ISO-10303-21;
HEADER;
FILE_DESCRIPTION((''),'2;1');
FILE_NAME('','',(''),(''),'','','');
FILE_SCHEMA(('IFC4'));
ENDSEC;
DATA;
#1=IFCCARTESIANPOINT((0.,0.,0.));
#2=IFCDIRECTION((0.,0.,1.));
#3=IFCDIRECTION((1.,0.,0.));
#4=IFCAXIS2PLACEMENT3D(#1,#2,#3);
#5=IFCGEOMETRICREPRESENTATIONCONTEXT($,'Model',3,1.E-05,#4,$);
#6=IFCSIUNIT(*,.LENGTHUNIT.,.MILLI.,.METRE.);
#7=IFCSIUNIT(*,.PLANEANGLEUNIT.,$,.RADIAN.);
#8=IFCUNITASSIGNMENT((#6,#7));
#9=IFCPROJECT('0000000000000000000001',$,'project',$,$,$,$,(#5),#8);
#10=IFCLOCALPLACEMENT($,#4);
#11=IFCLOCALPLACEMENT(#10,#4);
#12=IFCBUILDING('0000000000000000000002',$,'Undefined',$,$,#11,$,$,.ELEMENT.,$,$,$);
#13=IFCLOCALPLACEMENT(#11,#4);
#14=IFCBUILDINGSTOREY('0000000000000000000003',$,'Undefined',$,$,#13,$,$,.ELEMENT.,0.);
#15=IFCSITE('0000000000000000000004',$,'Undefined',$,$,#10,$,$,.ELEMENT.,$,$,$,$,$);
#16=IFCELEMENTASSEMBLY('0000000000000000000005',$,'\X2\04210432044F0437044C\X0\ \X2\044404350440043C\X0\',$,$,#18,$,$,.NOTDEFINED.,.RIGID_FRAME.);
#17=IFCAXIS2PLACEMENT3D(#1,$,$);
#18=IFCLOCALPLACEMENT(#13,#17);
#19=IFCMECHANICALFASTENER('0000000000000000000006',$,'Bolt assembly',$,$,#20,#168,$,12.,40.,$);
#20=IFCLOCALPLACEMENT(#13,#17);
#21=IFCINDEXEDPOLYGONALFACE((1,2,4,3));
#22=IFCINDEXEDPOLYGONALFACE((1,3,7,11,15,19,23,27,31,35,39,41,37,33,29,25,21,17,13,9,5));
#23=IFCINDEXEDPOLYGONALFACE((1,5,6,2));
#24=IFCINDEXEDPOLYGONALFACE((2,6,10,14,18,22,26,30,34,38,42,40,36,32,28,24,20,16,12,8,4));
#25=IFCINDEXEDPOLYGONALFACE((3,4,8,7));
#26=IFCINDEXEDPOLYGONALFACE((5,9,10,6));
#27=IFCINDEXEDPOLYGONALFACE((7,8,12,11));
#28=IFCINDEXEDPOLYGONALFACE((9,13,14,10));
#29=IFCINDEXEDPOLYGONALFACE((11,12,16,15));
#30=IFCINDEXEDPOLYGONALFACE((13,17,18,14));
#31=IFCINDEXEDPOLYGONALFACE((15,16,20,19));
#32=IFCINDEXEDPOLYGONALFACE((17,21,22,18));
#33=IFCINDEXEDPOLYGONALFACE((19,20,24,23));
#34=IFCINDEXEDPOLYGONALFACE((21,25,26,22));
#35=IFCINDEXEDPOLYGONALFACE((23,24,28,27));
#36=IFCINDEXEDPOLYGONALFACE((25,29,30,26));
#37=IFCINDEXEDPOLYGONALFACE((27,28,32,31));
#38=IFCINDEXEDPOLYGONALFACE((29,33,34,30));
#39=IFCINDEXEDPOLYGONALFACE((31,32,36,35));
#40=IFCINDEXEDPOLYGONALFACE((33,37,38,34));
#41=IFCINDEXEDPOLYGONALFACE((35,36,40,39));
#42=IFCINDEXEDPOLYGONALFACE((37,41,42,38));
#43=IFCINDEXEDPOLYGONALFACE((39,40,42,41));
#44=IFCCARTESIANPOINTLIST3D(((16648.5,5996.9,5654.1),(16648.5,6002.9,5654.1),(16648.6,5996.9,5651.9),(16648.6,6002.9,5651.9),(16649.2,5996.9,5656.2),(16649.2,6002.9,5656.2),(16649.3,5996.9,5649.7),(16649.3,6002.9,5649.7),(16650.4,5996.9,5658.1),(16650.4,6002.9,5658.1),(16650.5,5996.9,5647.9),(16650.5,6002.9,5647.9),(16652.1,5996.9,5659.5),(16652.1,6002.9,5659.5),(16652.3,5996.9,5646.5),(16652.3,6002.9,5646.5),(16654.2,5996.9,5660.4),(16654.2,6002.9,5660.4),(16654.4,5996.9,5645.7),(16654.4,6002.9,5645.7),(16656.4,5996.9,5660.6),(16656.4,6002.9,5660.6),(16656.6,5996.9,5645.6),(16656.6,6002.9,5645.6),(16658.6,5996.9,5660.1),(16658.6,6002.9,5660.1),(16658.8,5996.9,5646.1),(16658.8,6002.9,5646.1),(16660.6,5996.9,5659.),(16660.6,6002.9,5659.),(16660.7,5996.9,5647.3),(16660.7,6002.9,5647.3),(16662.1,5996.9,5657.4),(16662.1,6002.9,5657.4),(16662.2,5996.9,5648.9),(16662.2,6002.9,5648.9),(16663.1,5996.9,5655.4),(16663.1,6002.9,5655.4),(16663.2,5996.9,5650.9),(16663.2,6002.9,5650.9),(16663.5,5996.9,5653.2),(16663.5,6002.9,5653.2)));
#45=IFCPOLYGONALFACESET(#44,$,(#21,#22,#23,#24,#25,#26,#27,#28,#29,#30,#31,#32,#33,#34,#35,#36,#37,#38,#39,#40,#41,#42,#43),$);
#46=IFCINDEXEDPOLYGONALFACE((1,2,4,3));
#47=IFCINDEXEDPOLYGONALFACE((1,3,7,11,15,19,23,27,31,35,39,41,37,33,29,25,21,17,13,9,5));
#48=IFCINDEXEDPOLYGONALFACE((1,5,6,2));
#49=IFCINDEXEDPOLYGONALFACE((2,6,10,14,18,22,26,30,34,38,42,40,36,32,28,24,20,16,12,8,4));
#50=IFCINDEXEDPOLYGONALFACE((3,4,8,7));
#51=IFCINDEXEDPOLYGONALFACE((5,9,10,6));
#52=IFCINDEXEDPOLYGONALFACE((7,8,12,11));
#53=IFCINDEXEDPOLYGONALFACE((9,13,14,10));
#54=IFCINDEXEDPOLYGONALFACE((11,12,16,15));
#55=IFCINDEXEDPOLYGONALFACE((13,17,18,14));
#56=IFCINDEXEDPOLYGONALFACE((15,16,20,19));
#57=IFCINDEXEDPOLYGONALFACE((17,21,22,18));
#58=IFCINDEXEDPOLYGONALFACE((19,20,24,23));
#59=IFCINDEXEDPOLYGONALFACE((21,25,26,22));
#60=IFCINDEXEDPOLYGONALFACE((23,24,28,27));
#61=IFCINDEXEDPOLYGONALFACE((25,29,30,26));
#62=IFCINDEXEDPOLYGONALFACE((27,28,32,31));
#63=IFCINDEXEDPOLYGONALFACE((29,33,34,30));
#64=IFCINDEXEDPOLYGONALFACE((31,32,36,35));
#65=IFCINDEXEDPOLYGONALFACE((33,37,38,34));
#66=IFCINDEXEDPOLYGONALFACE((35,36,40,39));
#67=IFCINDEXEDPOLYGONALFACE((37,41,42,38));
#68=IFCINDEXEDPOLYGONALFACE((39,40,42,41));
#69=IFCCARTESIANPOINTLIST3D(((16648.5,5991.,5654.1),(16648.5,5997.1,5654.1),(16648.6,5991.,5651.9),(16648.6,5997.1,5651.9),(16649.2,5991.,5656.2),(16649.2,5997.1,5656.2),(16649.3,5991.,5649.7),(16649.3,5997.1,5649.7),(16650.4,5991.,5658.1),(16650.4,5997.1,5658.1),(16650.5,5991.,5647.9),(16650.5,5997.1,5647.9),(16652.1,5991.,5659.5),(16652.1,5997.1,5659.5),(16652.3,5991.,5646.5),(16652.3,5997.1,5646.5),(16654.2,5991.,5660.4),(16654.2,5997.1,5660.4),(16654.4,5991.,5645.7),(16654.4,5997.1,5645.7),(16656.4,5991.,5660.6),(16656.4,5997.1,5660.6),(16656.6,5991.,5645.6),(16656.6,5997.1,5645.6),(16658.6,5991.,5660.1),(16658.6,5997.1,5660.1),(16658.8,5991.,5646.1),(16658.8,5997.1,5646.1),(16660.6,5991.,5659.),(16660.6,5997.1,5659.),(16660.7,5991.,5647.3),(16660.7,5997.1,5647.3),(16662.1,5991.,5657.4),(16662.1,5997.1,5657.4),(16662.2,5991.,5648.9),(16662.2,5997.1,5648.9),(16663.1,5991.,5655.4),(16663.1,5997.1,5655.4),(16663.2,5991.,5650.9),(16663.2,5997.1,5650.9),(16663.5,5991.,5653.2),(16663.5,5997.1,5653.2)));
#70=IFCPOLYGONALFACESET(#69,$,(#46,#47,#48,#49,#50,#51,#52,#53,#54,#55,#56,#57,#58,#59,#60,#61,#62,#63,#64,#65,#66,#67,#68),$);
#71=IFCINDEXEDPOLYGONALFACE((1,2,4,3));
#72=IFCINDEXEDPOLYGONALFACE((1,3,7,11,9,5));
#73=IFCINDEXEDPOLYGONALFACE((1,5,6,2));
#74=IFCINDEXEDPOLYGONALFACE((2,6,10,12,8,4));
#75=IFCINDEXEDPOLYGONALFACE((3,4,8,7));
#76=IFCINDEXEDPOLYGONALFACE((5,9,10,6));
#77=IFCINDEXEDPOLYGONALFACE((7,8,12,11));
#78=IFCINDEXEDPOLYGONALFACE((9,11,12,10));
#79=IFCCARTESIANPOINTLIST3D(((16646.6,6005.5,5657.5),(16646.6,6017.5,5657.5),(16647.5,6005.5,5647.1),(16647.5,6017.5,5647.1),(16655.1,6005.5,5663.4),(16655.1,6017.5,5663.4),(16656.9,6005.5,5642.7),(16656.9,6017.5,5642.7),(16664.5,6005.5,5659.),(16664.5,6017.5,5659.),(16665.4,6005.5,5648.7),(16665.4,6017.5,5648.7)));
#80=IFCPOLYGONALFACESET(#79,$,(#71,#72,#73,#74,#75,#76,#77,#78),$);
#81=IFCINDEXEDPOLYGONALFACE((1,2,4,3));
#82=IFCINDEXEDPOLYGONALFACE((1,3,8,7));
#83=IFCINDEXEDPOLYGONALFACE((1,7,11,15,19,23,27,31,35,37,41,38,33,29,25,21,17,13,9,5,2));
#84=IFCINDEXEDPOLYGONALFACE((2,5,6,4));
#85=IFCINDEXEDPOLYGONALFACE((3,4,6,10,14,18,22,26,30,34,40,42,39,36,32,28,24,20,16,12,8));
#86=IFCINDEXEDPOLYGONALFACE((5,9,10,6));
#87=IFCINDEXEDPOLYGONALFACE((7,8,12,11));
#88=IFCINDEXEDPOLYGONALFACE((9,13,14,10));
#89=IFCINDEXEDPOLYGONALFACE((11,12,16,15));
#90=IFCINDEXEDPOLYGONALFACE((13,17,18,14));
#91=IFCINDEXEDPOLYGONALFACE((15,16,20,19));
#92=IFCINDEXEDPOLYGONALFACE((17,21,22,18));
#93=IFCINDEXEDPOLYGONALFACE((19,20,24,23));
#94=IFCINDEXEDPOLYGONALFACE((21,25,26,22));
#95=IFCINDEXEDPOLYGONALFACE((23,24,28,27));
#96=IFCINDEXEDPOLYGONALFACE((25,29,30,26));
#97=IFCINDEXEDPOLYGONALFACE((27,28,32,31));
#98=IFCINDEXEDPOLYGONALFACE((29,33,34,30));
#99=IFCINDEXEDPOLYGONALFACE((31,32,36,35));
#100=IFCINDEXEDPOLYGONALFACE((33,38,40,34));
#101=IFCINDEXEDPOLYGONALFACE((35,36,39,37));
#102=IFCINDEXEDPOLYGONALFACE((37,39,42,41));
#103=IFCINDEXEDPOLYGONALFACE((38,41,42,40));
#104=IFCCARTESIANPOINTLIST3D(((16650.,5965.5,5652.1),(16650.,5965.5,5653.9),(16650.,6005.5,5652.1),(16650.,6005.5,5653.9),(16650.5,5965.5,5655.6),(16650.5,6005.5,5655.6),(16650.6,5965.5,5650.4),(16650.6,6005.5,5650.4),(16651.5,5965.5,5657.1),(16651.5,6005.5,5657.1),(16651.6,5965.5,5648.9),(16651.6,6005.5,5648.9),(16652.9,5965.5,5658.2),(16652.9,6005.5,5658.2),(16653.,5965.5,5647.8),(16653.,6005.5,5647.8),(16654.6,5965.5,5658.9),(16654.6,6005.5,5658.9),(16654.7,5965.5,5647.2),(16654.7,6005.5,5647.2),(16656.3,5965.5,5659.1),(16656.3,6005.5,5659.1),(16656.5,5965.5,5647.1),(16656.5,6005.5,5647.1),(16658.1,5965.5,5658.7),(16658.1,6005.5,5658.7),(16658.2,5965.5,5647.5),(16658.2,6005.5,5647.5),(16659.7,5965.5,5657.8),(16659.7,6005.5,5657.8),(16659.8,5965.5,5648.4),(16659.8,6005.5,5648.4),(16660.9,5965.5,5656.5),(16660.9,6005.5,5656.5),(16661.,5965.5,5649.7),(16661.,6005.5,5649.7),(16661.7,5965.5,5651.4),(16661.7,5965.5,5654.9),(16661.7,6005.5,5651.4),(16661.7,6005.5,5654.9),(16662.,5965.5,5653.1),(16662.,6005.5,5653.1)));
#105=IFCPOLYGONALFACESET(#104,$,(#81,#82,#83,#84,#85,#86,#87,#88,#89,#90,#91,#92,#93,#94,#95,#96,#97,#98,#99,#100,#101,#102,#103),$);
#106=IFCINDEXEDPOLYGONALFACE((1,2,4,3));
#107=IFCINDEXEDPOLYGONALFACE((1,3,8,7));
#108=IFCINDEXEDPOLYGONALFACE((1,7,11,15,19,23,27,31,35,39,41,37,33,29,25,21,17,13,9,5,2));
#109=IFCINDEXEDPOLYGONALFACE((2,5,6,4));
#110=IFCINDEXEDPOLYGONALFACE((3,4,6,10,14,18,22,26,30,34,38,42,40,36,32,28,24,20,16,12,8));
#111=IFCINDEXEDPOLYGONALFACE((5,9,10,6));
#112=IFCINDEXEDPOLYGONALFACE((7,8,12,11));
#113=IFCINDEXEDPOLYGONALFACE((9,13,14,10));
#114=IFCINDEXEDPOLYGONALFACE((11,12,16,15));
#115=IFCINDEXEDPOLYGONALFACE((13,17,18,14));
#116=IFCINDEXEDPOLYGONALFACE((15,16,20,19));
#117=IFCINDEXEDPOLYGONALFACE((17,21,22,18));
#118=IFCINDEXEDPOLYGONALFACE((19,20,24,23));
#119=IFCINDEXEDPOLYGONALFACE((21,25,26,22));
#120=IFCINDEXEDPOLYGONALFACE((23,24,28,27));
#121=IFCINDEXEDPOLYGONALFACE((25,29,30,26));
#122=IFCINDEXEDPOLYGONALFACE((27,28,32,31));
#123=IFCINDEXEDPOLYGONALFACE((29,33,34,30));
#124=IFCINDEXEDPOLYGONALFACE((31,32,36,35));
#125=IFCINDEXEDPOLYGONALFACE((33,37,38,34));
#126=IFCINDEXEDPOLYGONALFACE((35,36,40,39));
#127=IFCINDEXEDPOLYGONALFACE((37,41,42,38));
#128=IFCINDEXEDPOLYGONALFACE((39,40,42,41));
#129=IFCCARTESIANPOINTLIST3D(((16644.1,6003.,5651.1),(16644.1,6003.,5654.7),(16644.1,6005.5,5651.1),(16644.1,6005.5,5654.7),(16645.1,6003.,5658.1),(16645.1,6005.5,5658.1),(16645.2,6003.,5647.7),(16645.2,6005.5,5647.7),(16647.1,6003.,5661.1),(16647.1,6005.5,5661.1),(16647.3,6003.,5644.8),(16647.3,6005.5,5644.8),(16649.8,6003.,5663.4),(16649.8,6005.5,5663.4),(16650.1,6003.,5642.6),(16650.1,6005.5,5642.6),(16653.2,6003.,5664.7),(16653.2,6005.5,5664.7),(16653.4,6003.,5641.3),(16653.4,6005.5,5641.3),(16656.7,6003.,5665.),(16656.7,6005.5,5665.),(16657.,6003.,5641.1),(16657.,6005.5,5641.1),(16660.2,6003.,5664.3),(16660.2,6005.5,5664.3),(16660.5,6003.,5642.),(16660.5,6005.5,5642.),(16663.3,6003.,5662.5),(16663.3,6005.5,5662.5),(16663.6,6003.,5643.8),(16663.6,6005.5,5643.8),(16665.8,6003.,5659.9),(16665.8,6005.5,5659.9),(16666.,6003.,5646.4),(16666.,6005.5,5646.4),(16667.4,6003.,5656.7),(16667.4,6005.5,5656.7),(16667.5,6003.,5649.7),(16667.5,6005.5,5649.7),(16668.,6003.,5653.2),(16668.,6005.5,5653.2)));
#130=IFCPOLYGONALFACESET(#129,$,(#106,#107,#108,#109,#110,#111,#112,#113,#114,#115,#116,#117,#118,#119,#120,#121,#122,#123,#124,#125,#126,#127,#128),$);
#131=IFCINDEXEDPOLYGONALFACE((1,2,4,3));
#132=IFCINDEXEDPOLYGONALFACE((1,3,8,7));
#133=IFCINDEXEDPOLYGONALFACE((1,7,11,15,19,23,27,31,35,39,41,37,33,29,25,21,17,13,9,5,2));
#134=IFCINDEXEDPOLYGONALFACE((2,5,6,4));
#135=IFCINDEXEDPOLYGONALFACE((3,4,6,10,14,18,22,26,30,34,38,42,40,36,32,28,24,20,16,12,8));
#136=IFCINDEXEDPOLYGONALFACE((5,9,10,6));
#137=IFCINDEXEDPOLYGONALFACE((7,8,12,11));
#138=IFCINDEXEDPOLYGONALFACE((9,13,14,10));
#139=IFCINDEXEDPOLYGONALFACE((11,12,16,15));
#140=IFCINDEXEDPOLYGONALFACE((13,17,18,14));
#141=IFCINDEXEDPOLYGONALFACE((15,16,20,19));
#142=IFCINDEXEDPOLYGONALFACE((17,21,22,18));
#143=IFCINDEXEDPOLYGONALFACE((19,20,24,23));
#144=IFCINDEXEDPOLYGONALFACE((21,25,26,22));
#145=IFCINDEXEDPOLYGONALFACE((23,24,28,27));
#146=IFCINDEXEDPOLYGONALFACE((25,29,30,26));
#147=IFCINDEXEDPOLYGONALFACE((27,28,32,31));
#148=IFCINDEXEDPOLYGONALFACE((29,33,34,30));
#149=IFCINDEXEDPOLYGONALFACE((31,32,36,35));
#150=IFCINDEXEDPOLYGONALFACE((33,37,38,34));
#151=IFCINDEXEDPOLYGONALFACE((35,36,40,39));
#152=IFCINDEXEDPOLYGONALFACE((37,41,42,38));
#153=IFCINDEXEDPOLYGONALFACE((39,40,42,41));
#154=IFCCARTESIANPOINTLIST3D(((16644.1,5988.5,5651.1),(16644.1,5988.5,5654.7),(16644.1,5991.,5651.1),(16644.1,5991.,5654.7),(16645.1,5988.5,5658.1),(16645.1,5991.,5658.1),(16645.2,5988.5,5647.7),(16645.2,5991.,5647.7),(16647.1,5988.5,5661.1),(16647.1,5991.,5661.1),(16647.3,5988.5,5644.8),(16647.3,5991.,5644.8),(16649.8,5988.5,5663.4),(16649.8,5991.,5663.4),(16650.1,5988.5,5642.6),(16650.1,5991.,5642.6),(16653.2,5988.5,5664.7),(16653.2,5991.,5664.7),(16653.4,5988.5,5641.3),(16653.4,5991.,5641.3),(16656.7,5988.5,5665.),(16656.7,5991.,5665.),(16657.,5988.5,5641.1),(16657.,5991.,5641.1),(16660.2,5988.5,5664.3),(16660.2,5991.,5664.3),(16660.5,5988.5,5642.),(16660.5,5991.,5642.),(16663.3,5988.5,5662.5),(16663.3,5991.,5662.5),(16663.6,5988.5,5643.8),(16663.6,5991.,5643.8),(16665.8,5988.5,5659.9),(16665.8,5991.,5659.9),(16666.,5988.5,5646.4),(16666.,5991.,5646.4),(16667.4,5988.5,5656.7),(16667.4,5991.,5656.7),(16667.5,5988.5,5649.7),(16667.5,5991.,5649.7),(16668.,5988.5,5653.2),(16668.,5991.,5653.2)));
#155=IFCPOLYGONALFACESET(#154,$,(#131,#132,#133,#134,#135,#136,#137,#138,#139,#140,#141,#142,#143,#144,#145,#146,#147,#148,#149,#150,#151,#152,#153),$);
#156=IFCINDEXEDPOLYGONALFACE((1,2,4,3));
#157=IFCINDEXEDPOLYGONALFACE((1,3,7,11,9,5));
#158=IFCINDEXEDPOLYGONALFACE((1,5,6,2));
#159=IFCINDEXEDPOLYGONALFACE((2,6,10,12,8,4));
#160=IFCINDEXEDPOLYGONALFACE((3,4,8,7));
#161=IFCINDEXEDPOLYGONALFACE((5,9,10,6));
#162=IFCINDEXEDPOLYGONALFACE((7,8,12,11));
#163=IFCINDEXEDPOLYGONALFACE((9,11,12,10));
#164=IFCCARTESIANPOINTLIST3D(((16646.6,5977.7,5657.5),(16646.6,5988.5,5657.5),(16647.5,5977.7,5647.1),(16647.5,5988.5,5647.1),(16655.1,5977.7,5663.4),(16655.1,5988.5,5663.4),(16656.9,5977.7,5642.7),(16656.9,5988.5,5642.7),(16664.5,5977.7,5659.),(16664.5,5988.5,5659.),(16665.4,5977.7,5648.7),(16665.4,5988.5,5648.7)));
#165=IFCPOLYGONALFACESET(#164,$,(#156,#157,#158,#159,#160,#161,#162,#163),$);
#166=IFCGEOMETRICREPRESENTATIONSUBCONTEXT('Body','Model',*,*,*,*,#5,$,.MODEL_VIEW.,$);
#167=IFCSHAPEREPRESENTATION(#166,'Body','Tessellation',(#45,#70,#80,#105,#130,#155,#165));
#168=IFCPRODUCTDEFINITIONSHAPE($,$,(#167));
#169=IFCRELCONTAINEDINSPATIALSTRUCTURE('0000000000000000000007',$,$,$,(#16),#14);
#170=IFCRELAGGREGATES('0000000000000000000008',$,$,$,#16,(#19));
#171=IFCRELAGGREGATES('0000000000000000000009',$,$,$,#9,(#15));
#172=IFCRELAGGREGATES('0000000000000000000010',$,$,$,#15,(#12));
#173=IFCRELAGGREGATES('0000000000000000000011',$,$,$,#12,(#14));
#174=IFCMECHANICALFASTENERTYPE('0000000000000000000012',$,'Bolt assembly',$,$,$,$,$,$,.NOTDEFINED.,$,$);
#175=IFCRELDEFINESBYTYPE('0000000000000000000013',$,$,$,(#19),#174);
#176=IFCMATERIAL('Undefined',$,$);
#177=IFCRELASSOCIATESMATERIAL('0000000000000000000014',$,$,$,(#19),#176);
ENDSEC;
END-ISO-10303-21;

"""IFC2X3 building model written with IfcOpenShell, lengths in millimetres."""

from ifc_helpers import new_model, si_unit, frame, origin_with_axes, origin_2d_with_axis, place, context, subcontext, project, spatial, polyline, circle, outline, extrude, source, transform, mapped, material, type_object, element, aggregate, save


model = new_model("IFC2X3")

# Units and contexts
model_context = context("Model", 3, precision=1e-05, world=origin_with_axes())
body_context = subcontext(model_context, "Body", "Model", "MODEL_VIEW")
ifc_project = project(units=[si_unit("LENGTHUNIT", "METRE", prefix="MILLI"), si_unit("PLANEANGLEUNIT", "RADIAN")], contexts=[model_context])

# Site, building, storey
site_placement = place(None, origin_with_axes())
site = spatial("IfcSite", under=ifc_project, at=site_placement, Name="Undefined", CompositionType="ELEMENT")
building_placement = place(site_placement, origin_with_axes())
building = spatial("IfcBuilding", under=site, at=building_placement, Name="Undefined", CompositionType="ELEMENT")
storey_placement = place(building_placement, origin_with_axes())
storey = spatial("IfcBuildingStorey", under=building, at=storey_placement, Name="Undefined", CompositionType="ELEMENT", Elevation=0.0)

# Element assembly
assembly_1_placement = place(storey_placement, origin_with_axes())
assembly_1 = element("IfcElementAssembly", 1, at=assembly_1_placement, inside=storey, Name="Связь ферм", AssemblyPlace="NOTDEFINED", PredefinedType="RIGID_FRAME")

# Mechanical fastener
ifc_material_1 = material(Name="Undefined")
mechanical_fastener_type = type_object("IfcMechanicalFastenerType", Name="Bolt assembly")
shared_shape_1 = source(origin_with_axes(), body_context, "Body", "SweptSolid", [
    extrude(circle(Radius=7.5, at=origin_2d_with_axis()), frame((0.0, 0.1, 0.0), z_axis=(0.0, 1.0, 0.0), x_axis=(1.0, 0.0, 0.0)), (0.0, 0.0, 1.0), 6.0),
    extrude(circle(Radius=7.5, at=origin_2d_with_axis()), frame((0.0, 5.9, 0.0), z_axis=(0.0, 1.0, 0.0), x_axis=(1.0, 0.0, 0.0)), (0.0, 0.0, 1.0), 6.1),
    extrude(outline(polyline([(10.4, 0.0), (5.2, 9.0), (-5.2, 9.0), (-10.4, 0.0), (-5.2, -9.0), (5.2, -9.0), (10.4, 0.0)])), frame((0.0, -14.5, 0.0), z_axis=(0.0, 1.0, 0.0), x_axis=(1.0, 0.0, 0.0)), (0.0, 0.0, 1.0), 12.0),
    extrude(circle(Radius=6.0, at=origin_2d_with_axis()), frame((0.0, -2.5, 0.0), z_axis=(0.0, 1.0, 0.0), x_axis=(1.0, 0.0, 0.0)), (0.0, 0.0, 1.0), 40.0),
    extrude(circle(Radius=12.0, at=origin_2d_with_axis()), frame((0.0, -2.5, 0.0), z_axis=(0.0, 1.0, 0.0), x_axis=(1.0, 0.0, 0.0)), (0.0, 0.0, 1.0), 2.5),
    extrude(circle(Radius=12.0, at=origin_2d_with_axis()), frame((0.0, 12.0, 0.0), z_axis=(0.0, 1.0, 0.0), x_axis=(1.0, 0.0, 0.0)), (0.0, 0.0, 1.0), 2.5),
    extrude(outline(polyline([(10.4, 0.0), (5.2, 9.0), (-5.2, 9.0), (-10.4, 0.0), (-5.2, -9.0), (5.2, -9.0), (10.4, 0.0)])), frame((0.0, 14.5, 0.0), z_axis=(0.0, 1.0, 0.0), x_axis=(1.0, 0.0, 0.0)), (0.0, 0.0, 1.0), 10.8),
])
mechanical_fastener_1_placement = place(assembly_1_placement, frame((16656.0, 6003.0, 5653.1), z_axis=(0.573078, 0.0, -0.819501), x_axis=(0.819501, 0.0, 0.573078)))
mechanical_fastener_1 = element("IfcMechanicalFastener", 2, at=mechanical_fastener_1_placement, type_object=mechanical_fastener_type, material=ifc_material_1, Name="Bolt assembly", NominalDiameter=12.0, NominalLength=40.0, context=body_context, shape_type="MappedRepresentation", body=[
    mapped(shared_shape_1, transform((0.0, 0.0, 0.0))),
])
aggregate(assembly_1, [mechanical_fastener_1])

save(model, "model.ifc")
